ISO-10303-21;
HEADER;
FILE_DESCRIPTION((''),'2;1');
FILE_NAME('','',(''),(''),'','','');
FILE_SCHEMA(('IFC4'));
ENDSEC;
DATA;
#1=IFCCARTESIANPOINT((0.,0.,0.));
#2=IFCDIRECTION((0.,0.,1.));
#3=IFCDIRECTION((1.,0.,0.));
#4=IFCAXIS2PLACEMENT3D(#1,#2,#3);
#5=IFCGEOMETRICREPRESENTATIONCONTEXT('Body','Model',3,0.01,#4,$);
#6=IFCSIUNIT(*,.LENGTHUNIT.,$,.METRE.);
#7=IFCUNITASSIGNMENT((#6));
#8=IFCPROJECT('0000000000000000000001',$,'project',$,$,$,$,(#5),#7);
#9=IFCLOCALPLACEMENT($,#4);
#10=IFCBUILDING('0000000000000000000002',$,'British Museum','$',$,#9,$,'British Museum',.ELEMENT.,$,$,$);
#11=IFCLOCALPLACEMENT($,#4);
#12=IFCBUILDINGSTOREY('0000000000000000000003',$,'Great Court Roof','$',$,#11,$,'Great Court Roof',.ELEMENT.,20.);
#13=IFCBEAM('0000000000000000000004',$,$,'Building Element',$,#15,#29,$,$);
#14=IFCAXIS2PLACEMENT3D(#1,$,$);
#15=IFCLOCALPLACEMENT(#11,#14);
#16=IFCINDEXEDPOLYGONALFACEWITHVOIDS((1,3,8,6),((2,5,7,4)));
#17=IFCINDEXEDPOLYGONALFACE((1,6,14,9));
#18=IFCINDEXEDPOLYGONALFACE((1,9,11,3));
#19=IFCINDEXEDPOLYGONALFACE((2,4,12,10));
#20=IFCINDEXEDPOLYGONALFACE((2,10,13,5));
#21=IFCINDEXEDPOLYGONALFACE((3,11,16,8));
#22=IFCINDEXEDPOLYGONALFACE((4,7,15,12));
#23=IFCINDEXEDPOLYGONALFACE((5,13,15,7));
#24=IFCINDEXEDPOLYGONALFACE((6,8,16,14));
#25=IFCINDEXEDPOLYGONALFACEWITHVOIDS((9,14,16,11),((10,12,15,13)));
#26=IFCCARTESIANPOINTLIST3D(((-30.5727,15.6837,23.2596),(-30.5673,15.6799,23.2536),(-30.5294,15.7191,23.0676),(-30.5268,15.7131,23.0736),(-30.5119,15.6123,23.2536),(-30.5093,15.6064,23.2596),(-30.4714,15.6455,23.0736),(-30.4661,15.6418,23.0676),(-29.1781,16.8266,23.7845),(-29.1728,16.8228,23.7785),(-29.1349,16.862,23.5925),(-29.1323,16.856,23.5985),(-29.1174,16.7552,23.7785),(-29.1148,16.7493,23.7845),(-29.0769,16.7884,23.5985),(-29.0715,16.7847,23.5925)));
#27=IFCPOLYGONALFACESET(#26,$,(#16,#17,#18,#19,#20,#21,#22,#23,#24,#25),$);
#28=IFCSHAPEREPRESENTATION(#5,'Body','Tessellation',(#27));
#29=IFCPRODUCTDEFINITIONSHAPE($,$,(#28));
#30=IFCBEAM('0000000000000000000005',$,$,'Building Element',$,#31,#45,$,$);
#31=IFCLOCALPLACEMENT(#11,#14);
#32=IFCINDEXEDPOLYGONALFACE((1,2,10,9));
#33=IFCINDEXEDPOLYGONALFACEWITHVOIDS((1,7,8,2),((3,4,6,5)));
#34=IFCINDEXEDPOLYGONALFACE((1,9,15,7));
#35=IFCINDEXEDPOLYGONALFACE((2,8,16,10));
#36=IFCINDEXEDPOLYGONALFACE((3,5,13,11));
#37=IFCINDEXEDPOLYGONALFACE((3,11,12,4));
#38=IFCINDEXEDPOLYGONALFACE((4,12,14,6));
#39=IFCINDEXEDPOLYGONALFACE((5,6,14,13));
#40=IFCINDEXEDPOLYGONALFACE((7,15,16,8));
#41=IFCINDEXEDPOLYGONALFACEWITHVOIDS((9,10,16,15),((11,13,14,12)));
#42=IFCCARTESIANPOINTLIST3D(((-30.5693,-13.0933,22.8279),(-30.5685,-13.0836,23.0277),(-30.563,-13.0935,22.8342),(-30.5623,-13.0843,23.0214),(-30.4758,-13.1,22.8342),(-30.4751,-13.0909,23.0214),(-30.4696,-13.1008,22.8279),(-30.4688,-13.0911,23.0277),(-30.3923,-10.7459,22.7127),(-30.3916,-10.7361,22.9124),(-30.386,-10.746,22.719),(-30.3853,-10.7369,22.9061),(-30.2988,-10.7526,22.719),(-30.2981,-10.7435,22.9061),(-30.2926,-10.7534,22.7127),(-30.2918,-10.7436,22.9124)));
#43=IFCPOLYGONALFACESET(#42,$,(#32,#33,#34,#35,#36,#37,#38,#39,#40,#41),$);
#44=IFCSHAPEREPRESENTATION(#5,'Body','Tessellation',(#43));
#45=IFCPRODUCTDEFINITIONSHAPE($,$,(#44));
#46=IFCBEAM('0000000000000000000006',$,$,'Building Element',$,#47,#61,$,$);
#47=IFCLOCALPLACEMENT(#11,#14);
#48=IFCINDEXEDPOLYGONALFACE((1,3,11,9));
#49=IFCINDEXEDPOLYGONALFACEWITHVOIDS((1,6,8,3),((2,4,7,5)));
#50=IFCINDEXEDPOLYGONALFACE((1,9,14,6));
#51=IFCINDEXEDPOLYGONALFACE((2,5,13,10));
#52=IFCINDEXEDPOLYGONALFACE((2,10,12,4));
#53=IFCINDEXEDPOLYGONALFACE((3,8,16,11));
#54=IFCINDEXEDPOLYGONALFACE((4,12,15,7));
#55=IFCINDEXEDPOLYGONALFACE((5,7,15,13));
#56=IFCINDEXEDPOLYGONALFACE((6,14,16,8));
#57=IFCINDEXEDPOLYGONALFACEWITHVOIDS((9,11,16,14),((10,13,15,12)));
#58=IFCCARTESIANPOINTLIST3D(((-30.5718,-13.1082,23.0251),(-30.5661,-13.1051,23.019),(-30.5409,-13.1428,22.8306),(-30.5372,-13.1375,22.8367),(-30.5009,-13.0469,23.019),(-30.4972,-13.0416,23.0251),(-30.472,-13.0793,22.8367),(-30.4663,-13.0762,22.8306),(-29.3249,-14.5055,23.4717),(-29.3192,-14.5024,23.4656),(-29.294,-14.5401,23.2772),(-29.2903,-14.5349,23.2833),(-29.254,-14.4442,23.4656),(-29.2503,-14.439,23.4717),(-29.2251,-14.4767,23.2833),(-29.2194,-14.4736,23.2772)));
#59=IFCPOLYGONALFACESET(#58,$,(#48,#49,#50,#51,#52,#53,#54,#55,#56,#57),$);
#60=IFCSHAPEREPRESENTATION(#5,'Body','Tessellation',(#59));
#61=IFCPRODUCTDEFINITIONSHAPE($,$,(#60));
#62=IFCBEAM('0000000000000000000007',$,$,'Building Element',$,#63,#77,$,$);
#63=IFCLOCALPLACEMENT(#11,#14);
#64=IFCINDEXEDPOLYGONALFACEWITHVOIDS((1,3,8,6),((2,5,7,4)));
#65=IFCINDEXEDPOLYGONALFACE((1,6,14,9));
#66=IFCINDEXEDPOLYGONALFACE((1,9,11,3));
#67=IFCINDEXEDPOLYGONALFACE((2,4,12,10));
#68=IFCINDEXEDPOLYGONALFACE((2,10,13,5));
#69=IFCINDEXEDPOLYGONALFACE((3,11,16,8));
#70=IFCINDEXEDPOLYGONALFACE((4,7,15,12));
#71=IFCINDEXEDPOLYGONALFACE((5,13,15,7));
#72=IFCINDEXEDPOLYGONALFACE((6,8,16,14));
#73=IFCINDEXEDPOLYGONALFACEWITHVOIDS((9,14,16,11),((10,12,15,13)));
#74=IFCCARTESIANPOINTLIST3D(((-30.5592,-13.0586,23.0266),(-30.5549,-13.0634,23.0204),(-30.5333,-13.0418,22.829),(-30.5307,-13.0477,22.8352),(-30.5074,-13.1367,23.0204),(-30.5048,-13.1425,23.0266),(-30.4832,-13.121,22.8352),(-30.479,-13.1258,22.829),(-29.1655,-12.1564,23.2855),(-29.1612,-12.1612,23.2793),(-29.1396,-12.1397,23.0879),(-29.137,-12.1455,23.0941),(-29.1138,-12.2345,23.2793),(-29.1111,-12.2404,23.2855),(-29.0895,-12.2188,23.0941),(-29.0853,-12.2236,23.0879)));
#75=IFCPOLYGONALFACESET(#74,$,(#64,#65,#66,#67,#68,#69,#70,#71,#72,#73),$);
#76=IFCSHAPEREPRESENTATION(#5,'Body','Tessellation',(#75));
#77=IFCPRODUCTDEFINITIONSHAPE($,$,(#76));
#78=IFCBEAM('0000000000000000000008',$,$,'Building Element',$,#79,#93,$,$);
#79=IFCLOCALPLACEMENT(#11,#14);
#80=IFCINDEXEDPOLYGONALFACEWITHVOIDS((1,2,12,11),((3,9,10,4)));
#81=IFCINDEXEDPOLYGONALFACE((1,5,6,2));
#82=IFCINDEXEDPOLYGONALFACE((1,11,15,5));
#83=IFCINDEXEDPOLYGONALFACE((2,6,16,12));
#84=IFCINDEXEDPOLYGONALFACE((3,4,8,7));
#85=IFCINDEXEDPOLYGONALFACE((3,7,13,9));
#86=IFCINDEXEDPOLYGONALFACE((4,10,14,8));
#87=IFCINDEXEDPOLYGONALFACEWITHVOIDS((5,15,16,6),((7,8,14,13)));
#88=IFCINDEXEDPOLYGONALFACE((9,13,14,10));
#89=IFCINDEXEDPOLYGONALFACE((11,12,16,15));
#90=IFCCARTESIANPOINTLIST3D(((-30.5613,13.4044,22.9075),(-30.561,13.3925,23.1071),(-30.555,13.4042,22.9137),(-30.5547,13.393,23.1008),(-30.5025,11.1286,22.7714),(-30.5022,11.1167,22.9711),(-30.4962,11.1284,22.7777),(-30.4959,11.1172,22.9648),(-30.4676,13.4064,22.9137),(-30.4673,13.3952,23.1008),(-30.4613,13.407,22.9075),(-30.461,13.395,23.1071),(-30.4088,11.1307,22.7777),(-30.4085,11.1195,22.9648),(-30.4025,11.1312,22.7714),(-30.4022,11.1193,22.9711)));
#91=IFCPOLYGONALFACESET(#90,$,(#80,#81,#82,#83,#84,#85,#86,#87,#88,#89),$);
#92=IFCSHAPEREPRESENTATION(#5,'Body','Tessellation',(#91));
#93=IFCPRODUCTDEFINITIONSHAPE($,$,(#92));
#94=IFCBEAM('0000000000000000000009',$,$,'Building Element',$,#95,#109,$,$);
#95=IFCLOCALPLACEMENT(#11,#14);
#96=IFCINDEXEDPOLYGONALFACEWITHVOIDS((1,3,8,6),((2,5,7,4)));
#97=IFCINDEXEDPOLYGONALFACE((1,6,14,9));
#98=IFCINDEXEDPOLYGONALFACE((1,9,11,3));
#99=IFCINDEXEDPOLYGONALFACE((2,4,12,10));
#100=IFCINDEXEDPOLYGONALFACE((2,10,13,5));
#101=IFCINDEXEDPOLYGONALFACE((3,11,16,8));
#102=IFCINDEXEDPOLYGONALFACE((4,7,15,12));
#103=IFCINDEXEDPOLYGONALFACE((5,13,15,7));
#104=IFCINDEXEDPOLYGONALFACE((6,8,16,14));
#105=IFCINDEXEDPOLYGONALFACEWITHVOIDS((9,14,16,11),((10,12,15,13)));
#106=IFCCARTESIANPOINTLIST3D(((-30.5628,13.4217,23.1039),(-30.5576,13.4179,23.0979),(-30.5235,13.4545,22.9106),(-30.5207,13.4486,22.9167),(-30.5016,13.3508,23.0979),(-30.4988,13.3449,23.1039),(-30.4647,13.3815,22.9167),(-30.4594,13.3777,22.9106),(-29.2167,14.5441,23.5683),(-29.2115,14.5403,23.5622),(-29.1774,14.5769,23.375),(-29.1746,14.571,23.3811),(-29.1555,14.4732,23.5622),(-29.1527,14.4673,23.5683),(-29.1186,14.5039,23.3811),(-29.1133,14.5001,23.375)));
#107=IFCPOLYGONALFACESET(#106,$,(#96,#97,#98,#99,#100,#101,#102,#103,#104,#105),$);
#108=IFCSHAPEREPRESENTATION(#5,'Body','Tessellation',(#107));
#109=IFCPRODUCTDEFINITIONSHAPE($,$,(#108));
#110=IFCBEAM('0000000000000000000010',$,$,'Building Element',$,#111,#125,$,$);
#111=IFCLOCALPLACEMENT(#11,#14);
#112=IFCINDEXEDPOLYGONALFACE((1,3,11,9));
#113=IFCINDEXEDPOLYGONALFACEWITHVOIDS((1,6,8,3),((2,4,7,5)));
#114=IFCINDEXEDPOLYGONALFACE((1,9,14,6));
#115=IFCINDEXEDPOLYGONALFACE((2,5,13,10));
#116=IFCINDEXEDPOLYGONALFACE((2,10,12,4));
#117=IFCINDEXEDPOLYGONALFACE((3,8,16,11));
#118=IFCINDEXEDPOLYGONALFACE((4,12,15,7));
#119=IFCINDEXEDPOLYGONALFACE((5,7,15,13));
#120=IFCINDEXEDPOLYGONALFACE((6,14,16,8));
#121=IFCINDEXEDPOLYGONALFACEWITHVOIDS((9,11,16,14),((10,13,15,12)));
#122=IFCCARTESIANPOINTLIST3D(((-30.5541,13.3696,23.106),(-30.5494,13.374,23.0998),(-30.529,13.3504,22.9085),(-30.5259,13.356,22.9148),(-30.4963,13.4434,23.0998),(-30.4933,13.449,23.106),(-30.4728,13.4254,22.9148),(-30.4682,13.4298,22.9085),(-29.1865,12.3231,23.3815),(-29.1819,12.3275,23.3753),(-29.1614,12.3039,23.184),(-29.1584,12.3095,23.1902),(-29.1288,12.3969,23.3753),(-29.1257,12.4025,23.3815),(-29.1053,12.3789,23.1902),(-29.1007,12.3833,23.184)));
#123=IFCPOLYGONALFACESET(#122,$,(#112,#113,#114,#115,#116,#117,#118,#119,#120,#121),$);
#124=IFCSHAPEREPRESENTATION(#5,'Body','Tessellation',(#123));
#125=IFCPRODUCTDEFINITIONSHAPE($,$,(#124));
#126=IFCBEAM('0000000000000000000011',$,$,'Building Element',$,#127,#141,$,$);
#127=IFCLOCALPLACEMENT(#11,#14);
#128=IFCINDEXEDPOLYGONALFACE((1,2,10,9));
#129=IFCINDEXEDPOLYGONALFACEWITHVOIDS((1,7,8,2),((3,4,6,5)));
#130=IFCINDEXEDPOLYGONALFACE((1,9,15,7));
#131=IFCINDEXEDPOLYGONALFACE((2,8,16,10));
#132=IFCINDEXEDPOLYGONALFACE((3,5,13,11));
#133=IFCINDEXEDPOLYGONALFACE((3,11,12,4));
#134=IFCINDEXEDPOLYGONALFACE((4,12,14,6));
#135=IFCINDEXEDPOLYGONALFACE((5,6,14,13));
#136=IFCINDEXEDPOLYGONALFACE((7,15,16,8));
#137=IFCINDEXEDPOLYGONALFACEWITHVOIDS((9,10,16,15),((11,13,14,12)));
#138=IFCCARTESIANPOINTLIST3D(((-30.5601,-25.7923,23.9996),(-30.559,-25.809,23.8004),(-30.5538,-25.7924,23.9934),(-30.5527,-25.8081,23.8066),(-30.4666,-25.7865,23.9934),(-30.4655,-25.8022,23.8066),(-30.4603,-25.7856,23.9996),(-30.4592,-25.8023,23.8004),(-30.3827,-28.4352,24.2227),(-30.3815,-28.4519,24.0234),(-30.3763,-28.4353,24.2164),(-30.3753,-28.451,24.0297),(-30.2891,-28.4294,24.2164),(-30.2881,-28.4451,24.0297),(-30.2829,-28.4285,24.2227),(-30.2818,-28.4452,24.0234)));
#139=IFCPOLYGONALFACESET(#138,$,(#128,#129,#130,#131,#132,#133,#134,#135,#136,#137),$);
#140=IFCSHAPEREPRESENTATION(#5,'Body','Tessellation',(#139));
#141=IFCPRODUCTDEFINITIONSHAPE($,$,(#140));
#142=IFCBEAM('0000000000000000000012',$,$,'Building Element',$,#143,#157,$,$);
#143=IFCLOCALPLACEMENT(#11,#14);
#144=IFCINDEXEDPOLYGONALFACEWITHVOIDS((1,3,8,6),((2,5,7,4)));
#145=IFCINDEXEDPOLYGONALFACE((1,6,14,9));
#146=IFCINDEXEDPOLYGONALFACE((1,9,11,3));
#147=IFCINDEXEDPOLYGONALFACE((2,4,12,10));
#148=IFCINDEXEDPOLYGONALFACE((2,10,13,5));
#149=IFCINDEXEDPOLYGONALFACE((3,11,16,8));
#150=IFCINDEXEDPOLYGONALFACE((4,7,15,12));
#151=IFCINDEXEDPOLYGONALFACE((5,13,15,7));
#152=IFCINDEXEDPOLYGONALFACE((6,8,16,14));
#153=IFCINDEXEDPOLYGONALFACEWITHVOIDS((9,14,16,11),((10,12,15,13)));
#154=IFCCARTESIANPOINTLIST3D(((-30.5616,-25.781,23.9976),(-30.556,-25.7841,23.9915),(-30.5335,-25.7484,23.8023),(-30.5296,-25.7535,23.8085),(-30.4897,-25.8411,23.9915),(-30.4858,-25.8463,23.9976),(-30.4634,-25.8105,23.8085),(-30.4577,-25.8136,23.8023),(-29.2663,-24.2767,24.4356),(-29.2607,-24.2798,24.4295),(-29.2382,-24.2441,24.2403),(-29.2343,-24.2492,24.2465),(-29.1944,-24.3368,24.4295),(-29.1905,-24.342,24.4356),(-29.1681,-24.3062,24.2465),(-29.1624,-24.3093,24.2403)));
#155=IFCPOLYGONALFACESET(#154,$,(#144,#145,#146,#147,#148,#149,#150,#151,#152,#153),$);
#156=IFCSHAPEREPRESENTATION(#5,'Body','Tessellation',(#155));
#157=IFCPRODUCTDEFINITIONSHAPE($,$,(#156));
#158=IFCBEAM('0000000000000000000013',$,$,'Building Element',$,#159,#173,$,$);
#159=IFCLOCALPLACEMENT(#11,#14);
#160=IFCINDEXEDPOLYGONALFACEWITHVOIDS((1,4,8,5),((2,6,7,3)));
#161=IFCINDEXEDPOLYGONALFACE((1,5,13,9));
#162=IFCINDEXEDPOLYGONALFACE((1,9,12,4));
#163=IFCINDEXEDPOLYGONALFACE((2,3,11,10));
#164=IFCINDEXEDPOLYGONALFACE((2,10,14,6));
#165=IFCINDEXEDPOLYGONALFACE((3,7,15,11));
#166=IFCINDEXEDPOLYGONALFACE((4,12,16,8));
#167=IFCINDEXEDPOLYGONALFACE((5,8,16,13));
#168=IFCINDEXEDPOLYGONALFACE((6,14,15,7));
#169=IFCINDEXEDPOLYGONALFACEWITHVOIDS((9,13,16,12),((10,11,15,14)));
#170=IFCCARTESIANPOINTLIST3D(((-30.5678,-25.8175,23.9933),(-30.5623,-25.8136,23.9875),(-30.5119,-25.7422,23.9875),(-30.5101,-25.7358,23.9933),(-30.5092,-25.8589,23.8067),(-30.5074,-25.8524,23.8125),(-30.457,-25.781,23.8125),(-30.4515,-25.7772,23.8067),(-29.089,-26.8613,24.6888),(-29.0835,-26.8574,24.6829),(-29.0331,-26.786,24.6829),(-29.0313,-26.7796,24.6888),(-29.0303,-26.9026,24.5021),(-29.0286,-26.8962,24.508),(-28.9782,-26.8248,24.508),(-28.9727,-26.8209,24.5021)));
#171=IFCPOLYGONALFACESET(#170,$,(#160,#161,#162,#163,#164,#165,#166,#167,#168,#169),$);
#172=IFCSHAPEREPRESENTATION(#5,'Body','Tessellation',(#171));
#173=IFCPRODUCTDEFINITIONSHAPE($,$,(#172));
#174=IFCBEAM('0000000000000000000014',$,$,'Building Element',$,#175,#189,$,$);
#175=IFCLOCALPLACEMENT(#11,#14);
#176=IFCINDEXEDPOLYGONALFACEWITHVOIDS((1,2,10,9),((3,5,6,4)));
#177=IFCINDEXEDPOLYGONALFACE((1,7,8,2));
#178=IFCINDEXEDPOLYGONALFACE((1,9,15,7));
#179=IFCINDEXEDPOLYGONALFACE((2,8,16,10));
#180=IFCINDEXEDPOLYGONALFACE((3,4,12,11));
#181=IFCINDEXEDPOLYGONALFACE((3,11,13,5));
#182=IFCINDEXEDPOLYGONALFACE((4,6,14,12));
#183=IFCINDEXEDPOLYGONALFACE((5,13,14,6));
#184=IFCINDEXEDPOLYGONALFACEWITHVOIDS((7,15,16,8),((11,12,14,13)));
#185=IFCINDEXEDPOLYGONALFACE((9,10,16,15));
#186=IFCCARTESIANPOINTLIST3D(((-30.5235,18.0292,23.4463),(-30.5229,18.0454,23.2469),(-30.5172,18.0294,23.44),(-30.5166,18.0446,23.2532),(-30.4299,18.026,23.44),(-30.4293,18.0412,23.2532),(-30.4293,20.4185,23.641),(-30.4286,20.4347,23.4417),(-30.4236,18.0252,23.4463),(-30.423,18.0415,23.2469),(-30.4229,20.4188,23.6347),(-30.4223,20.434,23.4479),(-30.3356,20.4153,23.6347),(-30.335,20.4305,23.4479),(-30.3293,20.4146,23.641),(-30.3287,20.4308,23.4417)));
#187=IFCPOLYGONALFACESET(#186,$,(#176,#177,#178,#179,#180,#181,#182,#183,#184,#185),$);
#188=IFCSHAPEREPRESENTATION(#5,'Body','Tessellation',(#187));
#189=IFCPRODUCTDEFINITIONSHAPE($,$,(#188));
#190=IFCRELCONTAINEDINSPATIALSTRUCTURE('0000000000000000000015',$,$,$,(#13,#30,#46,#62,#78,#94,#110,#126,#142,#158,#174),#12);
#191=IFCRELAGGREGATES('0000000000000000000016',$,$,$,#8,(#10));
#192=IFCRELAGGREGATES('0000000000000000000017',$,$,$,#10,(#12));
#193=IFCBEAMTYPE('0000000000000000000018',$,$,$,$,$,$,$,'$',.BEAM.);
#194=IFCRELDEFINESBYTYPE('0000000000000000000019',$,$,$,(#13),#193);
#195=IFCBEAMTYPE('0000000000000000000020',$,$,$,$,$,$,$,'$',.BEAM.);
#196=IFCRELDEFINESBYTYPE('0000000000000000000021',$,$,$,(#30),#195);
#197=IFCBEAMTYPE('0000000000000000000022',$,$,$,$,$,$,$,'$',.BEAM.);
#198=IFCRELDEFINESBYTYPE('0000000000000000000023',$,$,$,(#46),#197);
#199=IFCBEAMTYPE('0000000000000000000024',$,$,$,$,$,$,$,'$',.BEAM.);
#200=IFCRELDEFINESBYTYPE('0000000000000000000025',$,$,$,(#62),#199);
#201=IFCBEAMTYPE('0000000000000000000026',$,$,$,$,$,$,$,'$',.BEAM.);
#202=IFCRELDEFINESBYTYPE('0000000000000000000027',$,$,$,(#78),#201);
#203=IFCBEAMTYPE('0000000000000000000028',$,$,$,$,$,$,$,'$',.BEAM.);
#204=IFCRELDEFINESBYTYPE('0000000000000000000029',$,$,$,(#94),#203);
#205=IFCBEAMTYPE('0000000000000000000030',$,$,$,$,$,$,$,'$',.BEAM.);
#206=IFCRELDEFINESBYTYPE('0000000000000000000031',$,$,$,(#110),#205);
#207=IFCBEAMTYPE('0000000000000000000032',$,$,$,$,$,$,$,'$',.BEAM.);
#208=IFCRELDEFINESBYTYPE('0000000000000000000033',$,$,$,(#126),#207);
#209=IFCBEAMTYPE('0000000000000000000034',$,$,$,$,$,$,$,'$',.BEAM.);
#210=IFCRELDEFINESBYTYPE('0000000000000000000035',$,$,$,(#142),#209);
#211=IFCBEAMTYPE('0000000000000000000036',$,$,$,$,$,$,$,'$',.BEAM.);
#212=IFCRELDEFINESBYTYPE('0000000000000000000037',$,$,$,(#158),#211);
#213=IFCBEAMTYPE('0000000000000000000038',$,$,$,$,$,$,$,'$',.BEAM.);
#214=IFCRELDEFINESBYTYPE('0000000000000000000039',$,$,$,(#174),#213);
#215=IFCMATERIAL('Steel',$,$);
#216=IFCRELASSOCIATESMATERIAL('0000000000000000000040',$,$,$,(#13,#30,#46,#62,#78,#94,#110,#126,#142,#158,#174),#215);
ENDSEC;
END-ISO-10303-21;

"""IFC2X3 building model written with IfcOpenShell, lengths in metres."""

from ifc_helpers import new_model, si_unit, frame, origin_with_axes, origin_2d, place, context, project, spatial, hollow_rectangle, extrude, material, type_object, element, save


model = new_model("IFC2X3")

# Units and contexts
model_context = context("Model", 3, precision=0.01, world=origin_with_axes(), identifier="Body")
ifc_project = project(units=[si_unit("LENGTHUNIT", "METRE")], contexts=[model_context])

# Building, storey
building_placement = place(None, origin_with_axes())
building = spatial("IfcBuilding", under=ifc_project, at=building_placement, Name="British Museum", Description="$", LongName="British Museum", CompositionType="ELEMENT")
storey_placement = place(None, origin_with_axes())
storey = spatial("IfcBuildingStorey", under=building, at=storey_placement, Name="Great Court Roof", Description="$", LongName="Great Court Roof", CompositionType="ELEMENT", Elevation=20.0)

# Beams
ifc_material = material(Name="Steel")
beam_type_1 = type_object("IfcBeamType", ElementType="$", PredefinedType="BEAM")
beam_1_placement = place(None, origin_with_axes())
element("IfcBeam", 1, at=beam_1_placement, inside=storey, type_object=beam_type_1, material=ifc_material, Description="Building Element", context=model_context, shape_type="SweptSolid", body=[
    extrude(hollow_rectangle(XDim=0.1, YDim=0.2, WallThickness=0.0063, InnerFilletRadius=0.0, OuterFilletRadius=0.0, at=origin_2d()), frame((-30.5194, 15.6627, 23.1636), z_axis=(0.742605, 0.60861, 0.27952), x_axis=(-0.633877, 0.773434, 0.0)), (0.0, 0.0, 1.0), 1.8779),
])
beam_type_2 = type_object("IfcBeamType", ElementType="$", PredefinedType="BEAM")
beam_2_placement = place(None, origin_with_axes())
element("IfcBeam", 2, at=beam_2_placement, inside=storey, type_object=beam_type_2, material=ifc_material, Description="Building Element", context=model_context, shape_type="SweptSolid", body=[
    extrude(hollow_rectangle(XDim=0.1, YDim=0.2, WallThickness=0.0063, InnerFilletRadius=0.0, OuterFilletRadius=0.0, at=origin_2d()), frame((-30.5191, -13.0922, 22.9278), z_axis=(0.075095, 0.995976, -0.048915), x_axis=(-0.99717, 0.075185, 0.0)), (0.0, 0.0, 1.0), 2.3569),
])
beam_type_3 = type_object("IfcBeamType", ElementType="$", PredefinedType="BEAM")
beam_3_placement = place(None, origin_with_axes())
element("IfcBeam", 3, at=beam_3_placement, inside=storey, type_object=beam_type_3, material=ifc_material, Description="Building Element", context=model_context, shape_type="SweptSolid", body=[
    extrude(hollow_rectangle(XDim=0.1, YDim=0.2, WallThickness=0.0063, InnerFilletRadius=0.0, OuterFilletRadius=0.0, at=origin_2d()), frame((-30.5191, -13.0922, 22.9278), z_axis=(0.647643, -0.725776, 0.231967), x_axis=(0.746127, 0.665803, 0.0)), (0.0, 0.0, 1.0), 1.9253),
])
beam_type_4 = type_object("IfcBeamType", ElementType="$", PredefinedType="BEAM")
beam_4_placement = place(None, origin_with_axes())
element("IfcBeam", 4, at=beam_4_placement, inside=storey, type_object=beam_type_4, material=ifc_material, Description="Building Element", context=model_context, shape_type="SweptSolid", body=[
    extrude(hollow_rectangle(XDim=0.1, YDim=0.2, WallThickness=0.0063, InnerFilletRadius=0.0, OuterFilletRadius=0.0, at=origin_2d()), frame((-30.5191, -13.0922, 22.9278), z_axis=(0.829437, 0.53693, 0.15408), x_axis=(-0.543419, 0.839462, 0.0)), (0.0, 0.0, 1.0), 1.6803),
])
beam_type_5 = type_object("IfcBeamType", ElementType="$", PredefinedType="BEAM")
beam_5_placement = place(None, origin_with_axes())
element("IfcBeam", 5, at=beam_5_placement, inside=storey, type_object=beam_type_5, material=ifc_material, Description="Building Element", context=model_context, shape_type="SweptSolid", body=[
    extrude(hollow_rectangle(XDim=0.1, YDim=0.2, WallThickness=0.0063, InnerFilletRadius=0.0, OuterFilletRadius=0.0, at=origin_2d()), frame((-30.5111, 13.3997, 23.0073), z_axis=(0.02578, -0.997887, -0.05964), x_axis=(0.999666, 0.025826, 0.0)), (0.0, 0.0, 1.0), 2.2806),
])
beam_type_6 = type_object("IfcBeamType", ElementType="$", PredefinedType="BEAM")
beam_6_placement = place(None, origin_with_axes())
element("IfcBeam", 6, at=beam_6_placement, inside=storey, type_object=beam_type_6, material=ifc_material, Description="Building Element", context=model_context, shape_type="SweptSolid", body=[
    extrude(hollow_rectangle(XDim=0.1, YDim=0.2, WallThickness=0.0063, InnerFilletRadius=0.0, OuterFilletRadius=0.0, at=origin_2d()), frame((-30.5111, 13.3997, 23.0073), z_axis=(0.742428, 0.619037, 0.256114), x_axis=(-0.640396, 0.768045, 0.0)), (0.0, 0.0, 1.0), 1.8131),
])
beam_type_7 = type_object("IfcBeamType", ElementType="$", PredefinedType="BEAM")
beam_7_placement = place(None, origin_with_axes())
element("IfcBeam", 7, at=beam_7_placement, inside=storey, type_object=beam_type_7, material=ifc_material, Description="Building Element", context=model_context, shape_type="SweptSolid", body=[
    extrude(hollow_rectangle(XDim=0.1, YDim=0.2, WallThickness=0.0063, InnerFilletRadius=0.0, OuterFilletRadius=0.0, at=origin_2d()), frame((-30.5111, 13.3997, 23.0073), z_axis=(0.784191, -0.600075, 0.157973), x_axis=(0.607705, 0.794163, 0.0)), (0.0, 0.0, 1.0), 1.7439),
])
beam_type_8 = type_object("IfcBeamType", ElementType="$", PredefinedType="BEAM")
beam_8_placement = place(None, origin_with_axes())
element("IfcBeam", 8, at=beam_8_placement, inside=storey, type_object=beam_type_8, material=ifc_material, Description="Building Element", context=model_context, shape_type="SweptSolid", body=[
    extrude(hollow_rectangle(XDim=0.1, YDim=0.2, WallThickness=0.0063, InnerFilletRadius=0.0, OuterFilletRadius=0.0, at=origin_2d()), frame((-30.5097, -25.7973, 23.9), z_axis=(0.066756, -0.994234, 0.083916), x_axis=(0.997753, 0.066992, 0.0)), (0.0, 0.0, 1.0), 2.6582),
])
beam_type_9 = type_object("IfcBeamType", ElementType="$", PredefinedType="BEAM")
beam_9_placement = place(None, origin_with_axes())
element("IfcBeam", 9, at=beam_9_placement, inside=storey, type_object=beam_type_9, material=ifc_material, Description="Building Element", context=model_context, shape_type="SweptSolid", body=[
    extrude(hollow_rectangle(XDim=0.1, YDim=0.2, WallThickness=0.0063, InnerFilletRadius=0.0, OuterFilletRadius=0.0, at=origin_2d()), frame((-30.5097, -25.7973, 23.9), z_axis=(0.637175, 0.739993, 0.215447), x_axis=(-0.75779, 0.652499, 0.0)), (0.0, 0.0, 1.0), 2.0329),
])
beam_type_10 = type_object("IfcBeamType", ElementType="$", PredefinedType="BEAM")
beam_10_placement = place(None, origin_with_axes())
element("IfcBeam", 10, at=beam_10_placement, inside=storey, type_object=beam_type_10, material=ifc_material, Description="Building Element", context=model_context, shape_type="SweptSolid", body=[
    extrude(hollow_rectangle(XDim=0.1, YDim=0.2, WallThickness=0.0063, InnerFilletRadius=0.0, OuterFilletRadius=0.0, at=origin_2d()), frame((-30.5097, -25.7973, 23.9), z_axis=(0.762642, -0.538274, 0.358663), x_axis=(0.576639, 0.816999, 0.0)), (0.0, 0.0, 1.0), 1.9391),
])
beam_type_11 = type_object("IfcBeamType", ElementType="$", PredefinedType="BEAM")
beam_11_placement = place(None, origin_with_axes())
element("IfcBeam", 11, at=beam_11_placement, inside=storey, type_object=beam_type_11, material=ifc_material, Description="Building Element", context=model_context, shape_type="SweptSolid", body=[
    extrude(hollow_rectangle(XDim=0.1, YDim=0.2, WallThickness=0.0063, InnerFilletRadius=0.0, OuterFilletRadius=0.0, at=origin_2d()), frame((-30.4733, 18.0353, 23.3466), z_axis=(0.039299, 0.995925, 0.081177), x_axis=(-0.999222, 0.039429, 0.0)), (0.0, 0.0, 1.0), 2.3991),
])

save(model, "model.ifc")
